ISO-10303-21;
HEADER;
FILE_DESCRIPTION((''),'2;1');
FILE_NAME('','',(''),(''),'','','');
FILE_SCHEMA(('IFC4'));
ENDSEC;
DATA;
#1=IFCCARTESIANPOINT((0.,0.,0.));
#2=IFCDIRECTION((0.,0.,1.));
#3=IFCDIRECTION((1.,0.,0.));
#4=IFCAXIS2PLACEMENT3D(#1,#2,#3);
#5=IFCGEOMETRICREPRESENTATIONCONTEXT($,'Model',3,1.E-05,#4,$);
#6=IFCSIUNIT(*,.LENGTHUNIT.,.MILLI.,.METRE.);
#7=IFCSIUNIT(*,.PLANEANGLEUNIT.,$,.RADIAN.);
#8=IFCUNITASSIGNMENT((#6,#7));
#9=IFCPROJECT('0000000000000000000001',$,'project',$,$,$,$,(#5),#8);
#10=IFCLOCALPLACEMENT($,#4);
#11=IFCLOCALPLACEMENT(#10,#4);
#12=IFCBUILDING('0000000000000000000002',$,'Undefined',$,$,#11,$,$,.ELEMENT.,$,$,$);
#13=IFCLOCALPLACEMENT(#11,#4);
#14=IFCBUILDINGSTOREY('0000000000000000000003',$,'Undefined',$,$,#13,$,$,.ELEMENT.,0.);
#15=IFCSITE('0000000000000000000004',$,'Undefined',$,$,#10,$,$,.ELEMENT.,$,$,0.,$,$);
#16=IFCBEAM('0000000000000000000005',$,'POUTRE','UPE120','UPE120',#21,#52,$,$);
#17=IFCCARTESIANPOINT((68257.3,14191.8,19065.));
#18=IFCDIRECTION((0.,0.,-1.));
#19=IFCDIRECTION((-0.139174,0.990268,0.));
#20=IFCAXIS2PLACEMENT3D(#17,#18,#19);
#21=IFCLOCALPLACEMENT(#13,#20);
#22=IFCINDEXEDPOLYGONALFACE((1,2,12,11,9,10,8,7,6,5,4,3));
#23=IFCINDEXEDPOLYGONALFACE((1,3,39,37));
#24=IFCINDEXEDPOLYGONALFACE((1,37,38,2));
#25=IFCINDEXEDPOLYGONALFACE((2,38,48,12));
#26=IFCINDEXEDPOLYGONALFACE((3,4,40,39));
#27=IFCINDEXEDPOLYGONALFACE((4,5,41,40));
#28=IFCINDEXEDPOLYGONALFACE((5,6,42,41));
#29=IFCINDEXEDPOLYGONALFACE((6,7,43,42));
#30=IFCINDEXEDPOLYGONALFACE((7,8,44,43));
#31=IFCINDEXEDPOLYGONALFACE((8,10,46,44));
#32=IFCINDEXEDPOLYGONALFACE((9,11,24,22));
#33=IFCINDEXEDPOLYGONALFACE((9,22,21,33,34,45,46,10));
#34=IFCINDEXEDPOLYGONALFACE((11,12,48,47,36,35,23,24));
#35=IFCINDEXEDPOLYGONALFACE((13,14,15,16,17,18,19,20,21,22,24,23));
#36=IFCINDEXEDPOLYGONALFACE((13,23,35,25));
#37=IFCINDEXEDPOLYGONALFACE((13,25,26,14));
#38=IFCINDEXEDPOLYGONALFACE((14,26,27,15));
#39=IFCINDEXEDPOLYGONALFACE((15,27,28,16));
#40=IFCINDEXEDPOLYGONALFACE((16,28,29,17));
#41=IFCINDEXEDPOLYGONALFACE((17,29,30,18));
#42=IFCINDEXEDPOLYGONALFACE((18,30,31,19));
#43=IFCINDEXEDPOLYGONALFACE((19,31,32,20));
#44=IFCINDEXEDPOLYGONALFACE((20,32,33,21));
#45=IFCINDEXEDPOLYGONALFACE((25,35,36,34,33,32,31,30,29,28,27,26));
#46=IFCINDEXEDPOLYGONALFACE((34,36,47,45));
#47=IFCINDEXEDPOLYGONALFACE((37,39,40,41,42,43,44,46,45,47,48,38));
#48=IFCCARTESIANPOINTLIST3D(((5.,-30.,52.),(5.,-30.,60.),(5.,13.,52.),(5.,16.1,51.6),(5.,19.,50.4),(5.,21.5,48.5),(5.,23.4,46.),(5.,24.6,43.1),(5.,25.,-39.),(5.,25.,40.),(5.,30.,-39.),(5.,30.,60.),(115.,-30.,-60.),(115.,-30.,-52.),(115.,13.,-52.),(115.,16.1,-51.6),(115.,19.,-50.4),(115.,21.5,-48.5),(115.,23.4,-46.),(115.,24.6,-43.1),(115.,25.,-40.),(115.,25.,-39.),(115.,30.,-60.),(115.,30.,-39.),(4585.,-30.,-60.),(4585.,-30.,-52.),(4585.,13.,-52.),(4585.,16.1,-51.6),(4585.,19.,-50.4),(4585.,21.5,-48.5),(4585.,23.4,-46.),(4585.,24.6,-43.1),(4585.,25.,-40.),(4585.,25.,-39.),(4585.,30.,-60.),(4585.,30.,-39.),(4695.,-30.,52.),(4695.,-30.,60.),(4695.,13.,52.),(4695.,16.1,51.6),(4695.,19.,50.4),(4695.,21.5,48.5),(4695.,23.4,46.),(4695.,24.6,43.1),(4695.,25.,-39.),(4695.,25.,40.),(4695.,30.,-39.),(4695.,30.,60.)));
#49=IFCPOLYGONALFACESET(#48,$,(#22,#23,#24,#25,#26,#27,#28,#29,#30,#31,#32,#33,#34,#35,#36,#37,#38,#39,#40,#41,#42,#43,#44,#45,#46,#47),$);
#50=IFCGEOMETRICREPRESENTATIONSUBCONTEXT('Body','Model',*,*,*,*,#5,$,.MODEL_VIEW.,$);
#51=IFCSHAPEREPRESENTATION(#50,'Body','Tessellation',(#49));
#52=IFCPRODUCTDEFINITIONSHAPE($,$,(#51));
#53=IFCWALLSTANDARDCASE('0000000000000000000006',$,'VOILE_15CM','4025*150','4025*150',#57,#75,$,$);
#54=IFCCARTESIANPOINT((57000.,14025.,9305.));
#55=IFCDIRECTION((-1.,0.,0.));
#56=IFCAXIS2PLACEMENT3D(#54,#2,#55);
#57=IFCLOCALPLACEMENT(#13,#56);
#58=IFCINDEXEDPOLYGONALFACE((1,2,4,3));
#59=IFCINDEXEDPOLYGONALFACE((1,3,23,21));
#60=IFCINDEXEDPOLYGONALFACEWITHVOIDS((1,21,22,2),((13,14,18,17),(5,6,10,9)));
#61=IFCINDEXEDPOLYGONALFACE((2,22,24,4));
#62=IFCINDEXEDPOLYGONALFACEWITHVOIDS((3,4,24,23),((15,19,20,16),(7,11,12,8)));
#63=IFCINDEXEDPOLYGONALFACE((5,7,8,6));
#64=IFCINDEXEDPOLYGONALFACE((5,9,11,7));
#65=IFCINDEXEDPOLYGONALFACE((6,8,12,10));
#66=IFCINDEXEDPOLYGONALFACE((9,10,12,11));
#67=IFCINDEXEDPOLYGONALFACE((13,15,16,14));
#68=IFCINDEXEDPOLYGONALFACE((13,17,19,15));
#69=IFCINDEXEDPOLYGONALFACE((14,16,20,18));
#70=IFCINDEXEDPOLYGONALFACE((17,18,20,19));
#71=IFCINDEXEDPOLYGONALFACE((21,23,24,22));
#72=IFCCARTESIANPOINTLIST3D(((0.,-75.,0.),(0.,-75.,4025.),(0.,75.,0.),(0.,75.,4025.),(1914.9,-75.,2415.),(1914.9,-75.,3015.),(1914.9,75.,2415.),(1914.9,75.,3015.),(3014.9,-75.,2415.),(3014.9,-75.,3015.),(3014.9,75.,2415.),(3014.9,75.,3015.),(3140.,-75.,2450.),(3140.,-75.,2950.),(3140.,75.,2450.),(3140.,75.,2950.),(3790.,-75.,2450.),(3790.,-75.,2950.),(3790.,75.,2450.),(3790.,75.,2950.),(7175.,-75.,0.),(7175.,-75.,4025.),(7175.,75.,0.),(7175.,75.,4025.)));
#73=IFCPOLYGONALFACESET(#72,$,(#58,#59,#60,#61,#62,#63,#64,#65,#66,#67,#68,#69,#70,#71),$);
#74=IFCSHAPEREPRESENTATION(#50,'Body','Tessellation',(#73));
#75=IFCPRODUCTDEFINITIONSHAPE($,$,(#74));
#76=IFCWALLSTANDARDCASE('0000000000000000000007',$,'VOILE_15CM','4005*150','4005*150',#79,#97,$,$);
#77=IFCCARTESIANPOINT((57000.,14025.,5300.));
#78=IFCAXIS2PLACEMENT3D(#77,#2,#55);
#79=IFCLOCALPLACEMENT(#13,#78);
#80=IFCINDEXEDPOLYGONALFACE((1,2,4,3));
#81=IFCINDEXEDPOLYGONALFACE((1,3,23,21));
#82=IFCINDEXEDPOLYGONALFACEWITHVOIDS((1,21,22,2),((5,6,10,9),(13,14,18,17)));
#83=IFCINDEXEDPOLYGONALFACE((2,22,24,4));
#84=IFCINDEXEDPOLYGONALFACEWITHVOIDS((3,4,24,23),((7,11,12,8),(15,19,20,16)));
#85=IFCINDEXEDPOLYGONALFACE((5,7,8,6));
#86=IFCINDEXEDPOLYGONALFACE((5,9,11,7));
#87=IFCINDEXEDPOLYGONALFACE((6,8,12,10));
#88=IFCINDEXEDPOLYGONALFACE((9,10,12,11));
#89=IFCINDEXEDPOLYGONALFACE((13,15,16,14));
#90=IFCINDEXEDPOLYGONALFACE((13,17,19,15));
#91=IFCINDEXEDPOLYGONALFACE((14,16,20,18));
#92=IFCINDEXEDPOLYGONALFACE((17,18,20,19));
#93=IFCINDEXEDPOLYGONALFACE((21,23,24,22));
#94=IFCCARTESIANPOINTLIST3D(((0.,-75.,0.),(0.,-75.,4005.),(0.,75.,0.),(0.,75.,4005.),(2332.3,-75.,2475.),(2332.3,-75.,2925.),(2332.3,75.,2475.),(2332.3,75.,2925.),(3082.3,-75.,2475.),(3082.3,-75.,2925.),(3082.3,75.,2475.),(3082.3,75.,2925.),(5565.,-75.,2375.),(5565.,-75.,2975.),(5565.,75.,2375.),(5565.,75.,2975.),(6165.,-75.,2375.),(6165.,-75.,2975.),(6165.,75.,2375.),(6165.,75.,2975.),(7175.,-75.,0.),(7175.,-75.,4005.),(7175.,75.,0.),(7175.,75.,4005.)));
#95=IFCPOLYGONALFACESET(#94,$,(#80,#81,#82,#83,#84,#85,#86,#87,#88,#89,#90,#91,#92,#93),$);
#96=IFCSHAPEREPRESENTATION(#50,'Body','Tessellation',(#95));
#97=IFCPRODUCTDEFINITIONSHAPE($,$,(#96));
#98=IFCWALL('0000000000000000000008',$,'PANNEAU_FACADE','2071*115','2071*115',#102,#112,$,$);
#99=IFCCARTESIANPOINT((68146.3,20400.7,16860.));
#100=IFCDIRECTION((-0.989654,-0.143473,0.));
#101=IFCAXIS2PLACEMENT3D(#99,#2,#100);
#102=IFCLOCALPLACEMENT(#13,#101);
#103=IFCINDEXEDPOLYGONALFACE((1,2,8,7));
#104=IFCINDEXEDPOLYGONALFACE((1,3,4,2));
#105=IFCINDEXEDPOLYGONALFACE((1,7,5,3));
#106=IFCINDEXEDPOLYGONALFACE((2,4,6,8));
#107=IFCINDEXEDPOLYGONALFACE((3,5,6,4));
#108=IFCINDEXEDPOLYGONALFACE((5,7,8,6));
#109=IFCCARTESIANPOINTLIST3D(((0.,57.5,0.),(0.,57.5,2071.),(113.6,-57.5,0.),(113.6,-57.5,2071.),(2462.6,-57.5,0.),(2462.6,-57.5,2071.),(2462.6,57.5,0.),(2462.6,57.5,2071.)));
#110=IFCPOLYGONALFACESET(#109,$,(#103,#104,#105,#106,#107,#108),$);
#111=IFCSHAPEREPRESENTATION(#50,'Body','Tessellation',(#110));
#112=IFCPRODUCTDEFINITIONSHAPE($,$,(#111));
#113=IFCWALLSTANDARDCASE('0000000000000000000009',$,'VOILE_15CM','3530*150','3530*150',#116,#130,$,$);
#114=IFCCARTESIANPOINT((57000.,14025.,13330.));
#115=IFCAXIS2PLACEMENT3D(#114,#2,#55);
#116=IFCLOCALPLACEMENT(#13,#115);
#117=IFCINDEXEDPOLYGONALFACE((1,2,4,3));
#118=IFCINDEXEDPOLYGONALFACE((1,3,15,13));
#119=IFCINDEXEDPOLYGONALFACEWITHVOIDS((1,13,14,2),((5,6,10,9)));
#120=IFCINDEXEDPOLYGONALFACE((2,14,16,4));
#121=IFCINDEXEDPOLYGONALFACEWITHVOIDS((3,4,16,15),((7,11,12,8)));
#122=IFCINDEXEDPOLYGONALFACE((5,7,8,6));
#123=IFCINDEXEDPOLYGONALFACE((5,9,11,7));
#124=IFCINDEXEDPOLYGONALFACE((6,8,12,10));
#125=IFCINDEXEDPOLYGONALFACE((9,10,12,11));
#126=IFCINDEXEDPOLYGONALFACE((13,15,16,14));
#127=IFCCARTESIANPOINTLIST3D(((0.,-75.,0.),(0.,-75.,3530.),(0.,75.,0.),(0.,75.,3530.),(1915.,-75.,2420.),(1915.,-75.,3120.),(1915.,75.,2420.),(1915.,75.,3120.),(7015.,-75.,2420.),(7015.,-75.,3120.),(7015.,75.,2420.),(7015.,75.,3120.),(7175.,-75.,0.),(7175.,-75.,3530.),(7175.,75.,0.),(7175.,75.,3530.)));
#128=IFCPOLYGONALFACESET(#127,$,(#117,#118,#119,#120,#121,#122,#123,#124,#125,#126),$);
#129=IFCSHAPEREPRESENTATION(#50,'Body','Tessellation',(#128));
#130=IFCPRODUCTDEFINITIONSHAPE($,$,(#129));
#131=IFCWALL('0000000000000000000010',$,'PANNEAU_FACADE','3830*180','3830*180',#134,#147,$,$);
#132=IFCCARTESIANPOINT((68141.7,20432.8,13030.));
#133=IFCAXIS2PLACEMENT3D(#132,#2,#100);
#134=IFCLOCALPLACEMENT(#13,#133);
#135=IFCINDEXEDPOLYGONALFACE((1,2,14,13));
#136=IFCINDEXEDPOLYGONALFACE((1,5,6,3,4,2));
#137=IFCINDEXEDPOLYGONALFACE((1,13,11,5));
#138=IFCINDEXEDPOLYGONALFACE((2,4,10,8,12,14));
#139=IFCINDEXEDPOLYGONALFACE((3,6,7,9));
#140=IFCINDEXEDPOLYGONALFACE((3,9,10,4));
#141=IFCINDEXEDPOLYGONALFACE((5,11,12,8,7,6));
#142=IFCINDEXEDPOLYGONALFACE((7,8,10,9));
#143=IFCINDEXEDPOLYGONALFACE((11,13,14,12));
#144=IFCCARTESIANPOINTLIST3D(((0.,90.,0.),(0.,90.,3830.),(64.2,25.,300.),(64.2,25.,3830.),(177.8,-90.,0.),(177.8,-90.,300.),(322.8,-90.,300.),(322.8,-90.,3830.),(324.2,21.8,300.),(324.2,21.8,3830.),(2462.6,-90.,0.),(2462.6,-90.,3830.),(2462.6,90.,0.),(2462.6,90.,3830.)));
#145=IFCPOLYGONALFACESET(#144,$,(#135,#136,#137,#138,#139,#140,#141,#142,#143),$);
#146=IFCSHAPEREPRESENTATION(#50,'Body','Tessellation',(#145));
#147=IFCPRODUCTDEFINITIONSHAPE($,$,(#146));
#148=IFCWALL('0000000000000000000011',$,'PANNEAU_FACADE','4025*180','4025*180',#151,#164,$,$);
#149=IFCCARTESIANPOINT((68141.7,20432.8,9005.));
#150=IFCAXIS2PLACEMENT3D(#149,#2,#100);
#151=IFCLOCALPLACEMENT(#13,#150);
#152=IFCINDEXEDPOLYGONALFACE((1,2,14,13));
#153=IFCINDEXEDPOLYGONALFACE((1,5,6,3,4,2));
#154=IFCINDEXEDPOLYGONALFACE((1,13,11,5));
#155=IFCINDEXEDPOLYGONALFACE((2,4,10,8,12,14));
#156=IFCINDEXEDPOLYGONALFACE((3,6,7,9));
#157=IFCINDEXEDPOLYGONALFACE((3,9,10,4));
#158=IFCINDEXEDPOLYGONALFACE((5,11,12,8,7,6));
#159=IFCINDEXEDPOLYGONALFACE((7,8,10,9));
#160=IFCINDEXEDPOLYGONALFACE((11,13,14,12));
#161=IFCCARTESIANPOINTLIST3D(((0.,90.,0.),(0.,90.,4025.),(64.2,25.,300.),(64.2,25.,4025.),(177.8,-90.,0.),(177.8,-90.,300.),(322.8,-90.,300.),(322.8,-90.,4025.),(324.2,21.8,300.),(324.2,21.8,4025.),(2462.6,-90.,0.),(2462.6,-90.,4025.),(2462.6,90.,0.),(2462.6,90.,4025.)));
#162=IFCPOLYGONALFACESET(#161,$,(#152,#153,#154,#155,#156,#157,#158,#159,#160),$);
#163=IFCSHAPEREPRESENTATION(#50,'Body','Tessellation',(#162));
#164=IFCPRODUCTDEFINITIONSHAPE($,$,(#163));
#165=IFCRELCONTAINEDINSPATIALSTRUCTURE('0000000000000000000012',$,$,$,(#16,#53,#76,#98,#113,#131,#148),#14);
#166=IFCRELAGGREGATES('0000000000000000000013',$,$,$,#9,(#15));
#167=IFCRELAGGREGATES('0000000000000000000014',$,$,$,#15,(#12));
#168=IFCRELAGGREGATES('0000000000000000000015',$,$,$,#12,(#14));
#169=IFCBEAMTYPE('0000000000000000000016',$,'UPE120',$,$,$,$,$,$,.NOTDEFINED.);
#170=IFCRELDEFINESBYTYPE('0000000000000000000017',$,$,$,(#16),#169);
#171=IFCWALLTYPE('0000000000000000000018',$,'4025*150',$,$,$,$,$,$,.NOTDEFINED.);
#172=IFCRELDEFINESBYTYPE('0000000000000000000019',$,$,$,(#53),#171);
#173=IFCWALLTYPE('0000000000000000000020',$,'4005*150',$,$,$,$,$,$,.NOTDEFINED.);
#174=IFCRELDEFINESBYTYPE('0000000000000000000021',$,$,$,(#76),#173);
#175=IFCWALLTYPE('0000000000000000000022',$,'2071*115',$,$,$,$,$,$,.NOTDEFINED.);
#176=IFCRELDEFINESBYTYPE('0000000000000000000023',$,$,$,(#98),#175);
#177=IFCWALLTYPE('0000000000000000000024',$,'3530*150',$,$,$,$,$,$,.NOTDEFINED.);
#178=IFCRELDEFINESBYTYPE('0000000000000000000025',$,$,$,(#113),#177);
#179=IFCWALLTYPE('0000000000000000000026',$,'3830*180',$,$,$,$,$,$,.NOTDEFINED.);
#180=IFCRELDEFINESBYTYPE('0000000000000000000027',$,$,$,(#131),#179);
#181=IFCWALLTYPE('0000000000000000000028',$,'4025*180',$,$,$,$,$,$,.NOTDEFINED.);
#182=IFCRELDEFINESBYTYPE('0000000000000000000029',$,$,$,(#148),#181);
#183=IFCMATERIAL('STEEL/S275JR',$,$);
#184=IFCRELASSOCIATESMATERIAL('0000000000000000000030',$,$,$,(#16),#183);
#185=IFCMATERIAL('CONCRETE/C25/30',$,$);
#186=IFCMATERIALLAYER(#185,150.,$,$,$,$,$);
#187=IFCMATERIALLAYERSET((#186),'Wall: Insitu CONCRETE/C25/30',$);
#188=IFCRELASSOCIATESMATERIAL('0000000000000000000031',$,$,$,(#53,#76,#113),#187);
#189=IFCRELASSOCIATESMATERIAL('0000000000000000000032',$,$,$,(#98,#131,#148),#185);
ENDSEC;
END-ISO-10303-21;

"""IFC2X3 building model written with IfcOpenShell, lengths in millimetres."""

from ifc_helpers import new_model, si_unit, frame, frame_2d, origin_with_axes, origin_2d_with_axis, place, context, subcontext, project, spatial, rectangle, u_section, extrude, boolean, clip, halfspace, material, layer, layer_set, layer_usage, type_object, element, save


model = new_model("IFC2X3")

# Units and contexts
model_context = context("Model", 3, precision=1e-05, world=origin_with_axes())
body_context = subcontext(model_context, "Body", "Model", "MODEL_VIEW")
ifc_project = project(units=[si_unit("LENGTHUNIT", "METRE", prefix="MILLI"), si_unit("PLANEANGLEUNIT", "RADIAN")], contexts=[model_context])

# Site, building, storey
site_placement = place(None, origin_with_axes())
site = spatial("IfcSite", under=ifc_project, at=site_placement, Name="Undefined", CompositionType="ELEMENT", RefElevation=0.0)
building_placement = place(site_placement, origin_with_axes())
building = spatial("IfcBuilding", under=site, at=building_placement, Name="Undefined", CompositionType="ELEMENT")
storey_placement = place(building_placement, origin_with_axes())
storey = spatial("IfcBuildingStorey", under=building, at=storey_placement, Name="Undefined", CompositionType="ELEMENT", Elevation=0.0)

# Shared definitions
ifc_material_1 = material(Name="CONCRETE/C25/30")
ifc_material_2 = material(Name="STEEL/S275JR")

# Beam
beam_type_1 = type_object("IfcBeamType", Name="UPE120", PredefinedType="NOTDEFINED")
beam_1_placement = place(storey_placement, frame((68257.3, 14191.8, 19065.0), z_axis=(0.0, 0.0, -1.0), x_axis=(-0.139174, 0.990268, 0.0)))
element("IfcBeam", 1, at=beam_1_placement, inside=storey, type_object=beam_type_1, material=ifc_material_2, Name="POUTRE", Description="UPE120", ObjectType="UPE120", context=body_context, shape_type="CSG", body=[
    boolean("DIFFERENCE", boolean("DIFFERENCE", extrude(u_section(Depth=120.0, FlangeWidth=60.0, WebThickness=5.0, FlangeThickness=8.0, FilletRadius=12.0, at=origin_2d_with_axis()), frame((4695.0, 0.0, 0.0), z_axis=(-1.0, 0.0, 0.0), x_axis=(0.0, -1.0, 0.0)), (0.0, 0.0, 1.0), 4690.0), extrude(rectangle(XDim=22.0, YDim=112.0, at=origin_2d_with_axis()), frame((4641.0, -31.0, -50.0), z_axis=(0.000005, 1.0, 0.0), x_axis=(0.0, 0.0, 1.0)), (0.0, 0.0, 1.0), 62.0)), extrude(rectangle(XDim=22.0, YDim=112.0, at=origin_2d_with_axis()), frame((59.0, 31.0, -50.0), z_axis=(-0.000005, -1.0, 0.0), x_axis=(0.0, 0.0, 1.0)), (0.0, 0.0, 1.0), 62.0)),
])

# Walls
wall_type_1 = type_object("IfcWallType", Name="4025*150", PredefinedType="NOTDEFINED")
ifc_layer_1 = layer(ifc_material_1, 150.0)
ifc_layer_set_1 = layer_set([ifc_layer_1], Name="Wall: Insitu CONCRETE/C25/30")
ifc_layer_usage_1 = layer_usage(ifc_layer_set_1, "AXIS2", "POSITIVE", -75.0)
wall_1_placement = place(storey_placement, frame((57000.0, 14025.0, 9305.0), z_axis=(0.0, 0.0, 1.0), x_axis=(-1.0, 0.0, 0.0)))
element("IfcWallStandardCase", 2, at=wall_1_placement, inside=storey, type_object=wall_type_1, material=ifc_layer_usage_1, Name="VOILE_15CM", Description="4025*150", ObjectType="4025*150", context=body_context, shape_type="CSG", body=[
    boolean("DIFFERENCE", boolean("DIFFERENCE", extrude(rectangle(XDim=7175.0, YDim=150.0, at=frame_2d((0.0, 3587.5), x_axis=(0.0, -1.0))), frame((0.0, 0.0, 0.0), z_axis=(0.0, 0.0, 1.0), x_axis=(0.0, -1.0, 0.0)), (0.0, 0.0, 1.0), 4025.0), extrude(rectangle(XDim=650.0, YDim=500.0, at=origin_2d_with_axis()), frame((3465.0, -85.0, 2700.0), z_axis=(0.0, 1.0, 0.0), x_axis=(-1.0, 0.0, 0.0)), (0.0, 0.0, 1.0), 170.0)), extrude(rectangle(XDim=1100.0, YDim=600.0, at=origin_2d_with_axis()), frame((2464.9, -85.0, 2715.0), z_axis=(0.0, 1.0, 0.0), x_axis=(-1.0, 0.0, 0.0)), (0.0, 0.0, 1.0), 170.0)),
])
wall_type_2 = type_object("IfcWallType", Name="4005*150", PredefinedType="NOTDEFINED")
ifc_layer_usage_2 = layer_usage(ifc_layer_set_1, "AXIS2", "POSITIVE", -75.0)
wall_2_placement = place(storey_placement, frame((57000.0, 14025.0, 5300.0), z_axis=(0.0, 0.0, 1.0), x_axis=(-1.0, 0.0, 0.0)))
element("IfcWallStandardCase", 3, at=wall_2_placement, inside=storey, type_object=wall_type_2, material=ifc_layer_usage_2, Name="VOILE_15CM", Description="4005*150", ObjectType="4005*150", context=body_context, shape_type="CSG", body=[
    boolean("DIFFERENCE", boolean("DIFFERENCE", extrude(rectangle(XDim=7175.0, YDim=150.0, at=frame_2d((0.0, 3587.5), x_axis=(0.0, -1.0))), frame((0.0, 0.0, 0.0), z_axis=(0.0, 0.0, 1.0), x_axis=(0.0, -1.0, 0.0)), (0.0, 0.0, 1.0), 4005.0), extrude(rectangle(XDim=600.0, YDim=600.0, at=origin_2d_with_axis()), frame((5865.0, -85.0, 2675.0), z_axis=(0.0, 1.0, 0.0), x_axis=(-1.0, 0.0, 0.0)), (0.0, 0.0, 1.0), 170.0)), extrude(rectangle(XDim=750.0, YDim=450.0, at=origin_2d_with_axis()), frame((2707.3, -85.0, 2700.0), z_axis=(0.0, 1.0, 0.0), x_axis=(-1.0, 0.0, 0.0)), (0.0, 0.0, 1.0), 170.0)),
])
wall_type_3 = type_object("IfcWallType", Name="2071*115", PredefinedType="NOTDEFINED")
wall_3_placement = place(storey_placement, frame((68146.3, 20400.7, 16860.0), z_axis=(0.0, 0.0, 1.0), x_axis=(-0.989654, -0.143473, 0.0)))
element("IfcWall", 4, at=wall_3_placement, inside=storey, type_object=wall_type_3, material=ifc_material_1, Name="PANNEAU_FACADE", Description="2071*115", ObjectType="2071*115", context=body_context, shape_type="Clipping", body=[
    clip(extrude(rectangle(XDim=2597.5, YDim=115.0, at=frame_2d((0.0, 1163.9), x_axis=(0.0, -1.0))), frame((0.0, 0.0, 0.0), z_axis=(0.0, 0.0, 1.0), x_axis=(0.0, -1.0, 0.0)), (0.0, 0.0, 1.0), 2071.0), halfspace(frame((0.0, 57.5, 1035.5), z_axis=(-0.711444, -0.702742, 0.0), x_axis=(0.0, 0.0, 1.0)), False)),
])
ifc_layer_usage_3 = layer_usage(ifc_layer_set_1, "AXIS2", "POSITIVE", -75.0)
wall_type_4 = type_object("IfcWallType", Name="3530*150", PredefinedType="NOTDEFINED")
wall_4_placement = place(storey_placement, frame((57000.0, 14025.0, 13330.0), z_axis=(0.0, 0.0, 1.0), x_axis=(-1.0, 0.0, 0.0)))
element("IfcWallStandardCase", 5, at=wall_4_placement, inside=storey, type_object=wall_type_4, material=ifc_layer_usage_3, Name="VOILE_15CM", Description="3530*150", ObjectType="3530*150", context=body_context, shape_type="CSG", body=[
    boolean("DIFFERENCE", extrude(rectangle(XDim=7175.0, YDim=150.0, at=frame_2d((0.0, 3587.5), x_axis=(0.0, -1.0))), frame((0.0, 0.0, 0.0), z_axis=(0.0, 0.0, 1.0), x_axis=(0.0, -1.0, 0.0)), (0.0, 0.0, 1.0), 3530.0), extrude(rectangle(XDim=5100.0, YDim=700.0, at=origin_2d_with_axis()), frame((4465.0, -85.0, 2770.0), z_axis=(0.0, 1.0, 0.0), x_axis=(-1.0, 0.0, 0.0)), (0.0, 0.0, 1.0), 170.0)),
])
wall_type_5 = type_object("IfcWallType", Name="3830*180", PredefinedType="NOTDEFINED")
wall_5_placement = place(storey_placement, frame((68141.7, 20432.8, 13030.0), z_axis=(0.0, 0.0, 1.0), x_axis=(-0.989654, -0.143473, 0.0)))
element("IfcWall", 6, at=wall_5_placement, inside=storey, type_object=wall_type_5, material=ifc_material_1, Name="PANNEAU_FACADE", Description="3830*180", ObjectType="3830*180", context=body_context, shape_type="CSG", body=[
    boolean("DIFFERENCE", boolean("DIFFERENCE", extrude(rectangle(XDim=2673.7, YDim=180.0, at=frame_2d((0.0, 1125.8), x_axis=(0.0, -1.0))), frame((0.0, 0.0, 0.0), z_axis=(0.0, 0.0, 1.0), x_axis=(0.0, -1.0, 0.0)), (0.0, 0.0, 1.0), 3830.0), extrude(rectangle(XDim=260.0, YDim=260.0, at=origin_2d_with_axis()), frame((192.6, -106.6, 3830.0), z_axis=(0.0, 0.0, -1.0), x_axis=(-0.012306, -0.999924, 0.0)), (0.0, 0.0, 1.0), 3530.0)), halfspace(frame((0.0, 90.0, 1915.0), z_axis=(-0.711444, -0.702742, 0.0), x_axis=(0.0, 0.0, 1.0)), False)),
])
wall_type_6 = type_object("IfcWallType", Name="4025*180", PredefinedType="NOTDEFINED")
wall_6_placement = place(storey_placement, frame((68141.7, 20432.8, 9005.0), z_axis=(0.0, 0.0, 1.0), x_axis=(-0.989654, -0.143473, 0.0)))
element("IfcWall", 7, at=wall_6_placement, inside=storey, type_object=wall_type_6, material=ifc_material_1, Name="PANNEAU_FACADE", Description="4025*180", ObjectType="4025*180", context=body_context, shape_type="CSG", body=[
    boolean("DIFFERENCE", boolean("DIFFERENCE", extrude(rectangle(XDim=2673.7, YDim=180.0, at=frame_2d((0.0, 1125.8), x_axis=(0.0, -1.0))), frame((0.0, 0.0, 0.0), z_axis=(0.0, 0.0, 1.0), x_axis=(0.0, -1.0, 0.0)), (0.0, 0.0, 1.0), 4025.0), extrude(rectangle(XDim=260.0, YDim=260.0, at=origin_2d_with_axis()), frame((192.6, -106.6, 4025.0), z_axis=(0.0, 0.0, -1.0), x_axis=(-0.012306, -0.999924, 0.0)), (0.0, 0.0, 1.0), 3725.0)), halfspace(frame((0.0, 90.0, 2012.5), z_axis=(-0.711444, -0.702742, 0.0), x_axis=(0.0, 0.0, 1.0)), False)),
])

save(model, "model.ifc")
